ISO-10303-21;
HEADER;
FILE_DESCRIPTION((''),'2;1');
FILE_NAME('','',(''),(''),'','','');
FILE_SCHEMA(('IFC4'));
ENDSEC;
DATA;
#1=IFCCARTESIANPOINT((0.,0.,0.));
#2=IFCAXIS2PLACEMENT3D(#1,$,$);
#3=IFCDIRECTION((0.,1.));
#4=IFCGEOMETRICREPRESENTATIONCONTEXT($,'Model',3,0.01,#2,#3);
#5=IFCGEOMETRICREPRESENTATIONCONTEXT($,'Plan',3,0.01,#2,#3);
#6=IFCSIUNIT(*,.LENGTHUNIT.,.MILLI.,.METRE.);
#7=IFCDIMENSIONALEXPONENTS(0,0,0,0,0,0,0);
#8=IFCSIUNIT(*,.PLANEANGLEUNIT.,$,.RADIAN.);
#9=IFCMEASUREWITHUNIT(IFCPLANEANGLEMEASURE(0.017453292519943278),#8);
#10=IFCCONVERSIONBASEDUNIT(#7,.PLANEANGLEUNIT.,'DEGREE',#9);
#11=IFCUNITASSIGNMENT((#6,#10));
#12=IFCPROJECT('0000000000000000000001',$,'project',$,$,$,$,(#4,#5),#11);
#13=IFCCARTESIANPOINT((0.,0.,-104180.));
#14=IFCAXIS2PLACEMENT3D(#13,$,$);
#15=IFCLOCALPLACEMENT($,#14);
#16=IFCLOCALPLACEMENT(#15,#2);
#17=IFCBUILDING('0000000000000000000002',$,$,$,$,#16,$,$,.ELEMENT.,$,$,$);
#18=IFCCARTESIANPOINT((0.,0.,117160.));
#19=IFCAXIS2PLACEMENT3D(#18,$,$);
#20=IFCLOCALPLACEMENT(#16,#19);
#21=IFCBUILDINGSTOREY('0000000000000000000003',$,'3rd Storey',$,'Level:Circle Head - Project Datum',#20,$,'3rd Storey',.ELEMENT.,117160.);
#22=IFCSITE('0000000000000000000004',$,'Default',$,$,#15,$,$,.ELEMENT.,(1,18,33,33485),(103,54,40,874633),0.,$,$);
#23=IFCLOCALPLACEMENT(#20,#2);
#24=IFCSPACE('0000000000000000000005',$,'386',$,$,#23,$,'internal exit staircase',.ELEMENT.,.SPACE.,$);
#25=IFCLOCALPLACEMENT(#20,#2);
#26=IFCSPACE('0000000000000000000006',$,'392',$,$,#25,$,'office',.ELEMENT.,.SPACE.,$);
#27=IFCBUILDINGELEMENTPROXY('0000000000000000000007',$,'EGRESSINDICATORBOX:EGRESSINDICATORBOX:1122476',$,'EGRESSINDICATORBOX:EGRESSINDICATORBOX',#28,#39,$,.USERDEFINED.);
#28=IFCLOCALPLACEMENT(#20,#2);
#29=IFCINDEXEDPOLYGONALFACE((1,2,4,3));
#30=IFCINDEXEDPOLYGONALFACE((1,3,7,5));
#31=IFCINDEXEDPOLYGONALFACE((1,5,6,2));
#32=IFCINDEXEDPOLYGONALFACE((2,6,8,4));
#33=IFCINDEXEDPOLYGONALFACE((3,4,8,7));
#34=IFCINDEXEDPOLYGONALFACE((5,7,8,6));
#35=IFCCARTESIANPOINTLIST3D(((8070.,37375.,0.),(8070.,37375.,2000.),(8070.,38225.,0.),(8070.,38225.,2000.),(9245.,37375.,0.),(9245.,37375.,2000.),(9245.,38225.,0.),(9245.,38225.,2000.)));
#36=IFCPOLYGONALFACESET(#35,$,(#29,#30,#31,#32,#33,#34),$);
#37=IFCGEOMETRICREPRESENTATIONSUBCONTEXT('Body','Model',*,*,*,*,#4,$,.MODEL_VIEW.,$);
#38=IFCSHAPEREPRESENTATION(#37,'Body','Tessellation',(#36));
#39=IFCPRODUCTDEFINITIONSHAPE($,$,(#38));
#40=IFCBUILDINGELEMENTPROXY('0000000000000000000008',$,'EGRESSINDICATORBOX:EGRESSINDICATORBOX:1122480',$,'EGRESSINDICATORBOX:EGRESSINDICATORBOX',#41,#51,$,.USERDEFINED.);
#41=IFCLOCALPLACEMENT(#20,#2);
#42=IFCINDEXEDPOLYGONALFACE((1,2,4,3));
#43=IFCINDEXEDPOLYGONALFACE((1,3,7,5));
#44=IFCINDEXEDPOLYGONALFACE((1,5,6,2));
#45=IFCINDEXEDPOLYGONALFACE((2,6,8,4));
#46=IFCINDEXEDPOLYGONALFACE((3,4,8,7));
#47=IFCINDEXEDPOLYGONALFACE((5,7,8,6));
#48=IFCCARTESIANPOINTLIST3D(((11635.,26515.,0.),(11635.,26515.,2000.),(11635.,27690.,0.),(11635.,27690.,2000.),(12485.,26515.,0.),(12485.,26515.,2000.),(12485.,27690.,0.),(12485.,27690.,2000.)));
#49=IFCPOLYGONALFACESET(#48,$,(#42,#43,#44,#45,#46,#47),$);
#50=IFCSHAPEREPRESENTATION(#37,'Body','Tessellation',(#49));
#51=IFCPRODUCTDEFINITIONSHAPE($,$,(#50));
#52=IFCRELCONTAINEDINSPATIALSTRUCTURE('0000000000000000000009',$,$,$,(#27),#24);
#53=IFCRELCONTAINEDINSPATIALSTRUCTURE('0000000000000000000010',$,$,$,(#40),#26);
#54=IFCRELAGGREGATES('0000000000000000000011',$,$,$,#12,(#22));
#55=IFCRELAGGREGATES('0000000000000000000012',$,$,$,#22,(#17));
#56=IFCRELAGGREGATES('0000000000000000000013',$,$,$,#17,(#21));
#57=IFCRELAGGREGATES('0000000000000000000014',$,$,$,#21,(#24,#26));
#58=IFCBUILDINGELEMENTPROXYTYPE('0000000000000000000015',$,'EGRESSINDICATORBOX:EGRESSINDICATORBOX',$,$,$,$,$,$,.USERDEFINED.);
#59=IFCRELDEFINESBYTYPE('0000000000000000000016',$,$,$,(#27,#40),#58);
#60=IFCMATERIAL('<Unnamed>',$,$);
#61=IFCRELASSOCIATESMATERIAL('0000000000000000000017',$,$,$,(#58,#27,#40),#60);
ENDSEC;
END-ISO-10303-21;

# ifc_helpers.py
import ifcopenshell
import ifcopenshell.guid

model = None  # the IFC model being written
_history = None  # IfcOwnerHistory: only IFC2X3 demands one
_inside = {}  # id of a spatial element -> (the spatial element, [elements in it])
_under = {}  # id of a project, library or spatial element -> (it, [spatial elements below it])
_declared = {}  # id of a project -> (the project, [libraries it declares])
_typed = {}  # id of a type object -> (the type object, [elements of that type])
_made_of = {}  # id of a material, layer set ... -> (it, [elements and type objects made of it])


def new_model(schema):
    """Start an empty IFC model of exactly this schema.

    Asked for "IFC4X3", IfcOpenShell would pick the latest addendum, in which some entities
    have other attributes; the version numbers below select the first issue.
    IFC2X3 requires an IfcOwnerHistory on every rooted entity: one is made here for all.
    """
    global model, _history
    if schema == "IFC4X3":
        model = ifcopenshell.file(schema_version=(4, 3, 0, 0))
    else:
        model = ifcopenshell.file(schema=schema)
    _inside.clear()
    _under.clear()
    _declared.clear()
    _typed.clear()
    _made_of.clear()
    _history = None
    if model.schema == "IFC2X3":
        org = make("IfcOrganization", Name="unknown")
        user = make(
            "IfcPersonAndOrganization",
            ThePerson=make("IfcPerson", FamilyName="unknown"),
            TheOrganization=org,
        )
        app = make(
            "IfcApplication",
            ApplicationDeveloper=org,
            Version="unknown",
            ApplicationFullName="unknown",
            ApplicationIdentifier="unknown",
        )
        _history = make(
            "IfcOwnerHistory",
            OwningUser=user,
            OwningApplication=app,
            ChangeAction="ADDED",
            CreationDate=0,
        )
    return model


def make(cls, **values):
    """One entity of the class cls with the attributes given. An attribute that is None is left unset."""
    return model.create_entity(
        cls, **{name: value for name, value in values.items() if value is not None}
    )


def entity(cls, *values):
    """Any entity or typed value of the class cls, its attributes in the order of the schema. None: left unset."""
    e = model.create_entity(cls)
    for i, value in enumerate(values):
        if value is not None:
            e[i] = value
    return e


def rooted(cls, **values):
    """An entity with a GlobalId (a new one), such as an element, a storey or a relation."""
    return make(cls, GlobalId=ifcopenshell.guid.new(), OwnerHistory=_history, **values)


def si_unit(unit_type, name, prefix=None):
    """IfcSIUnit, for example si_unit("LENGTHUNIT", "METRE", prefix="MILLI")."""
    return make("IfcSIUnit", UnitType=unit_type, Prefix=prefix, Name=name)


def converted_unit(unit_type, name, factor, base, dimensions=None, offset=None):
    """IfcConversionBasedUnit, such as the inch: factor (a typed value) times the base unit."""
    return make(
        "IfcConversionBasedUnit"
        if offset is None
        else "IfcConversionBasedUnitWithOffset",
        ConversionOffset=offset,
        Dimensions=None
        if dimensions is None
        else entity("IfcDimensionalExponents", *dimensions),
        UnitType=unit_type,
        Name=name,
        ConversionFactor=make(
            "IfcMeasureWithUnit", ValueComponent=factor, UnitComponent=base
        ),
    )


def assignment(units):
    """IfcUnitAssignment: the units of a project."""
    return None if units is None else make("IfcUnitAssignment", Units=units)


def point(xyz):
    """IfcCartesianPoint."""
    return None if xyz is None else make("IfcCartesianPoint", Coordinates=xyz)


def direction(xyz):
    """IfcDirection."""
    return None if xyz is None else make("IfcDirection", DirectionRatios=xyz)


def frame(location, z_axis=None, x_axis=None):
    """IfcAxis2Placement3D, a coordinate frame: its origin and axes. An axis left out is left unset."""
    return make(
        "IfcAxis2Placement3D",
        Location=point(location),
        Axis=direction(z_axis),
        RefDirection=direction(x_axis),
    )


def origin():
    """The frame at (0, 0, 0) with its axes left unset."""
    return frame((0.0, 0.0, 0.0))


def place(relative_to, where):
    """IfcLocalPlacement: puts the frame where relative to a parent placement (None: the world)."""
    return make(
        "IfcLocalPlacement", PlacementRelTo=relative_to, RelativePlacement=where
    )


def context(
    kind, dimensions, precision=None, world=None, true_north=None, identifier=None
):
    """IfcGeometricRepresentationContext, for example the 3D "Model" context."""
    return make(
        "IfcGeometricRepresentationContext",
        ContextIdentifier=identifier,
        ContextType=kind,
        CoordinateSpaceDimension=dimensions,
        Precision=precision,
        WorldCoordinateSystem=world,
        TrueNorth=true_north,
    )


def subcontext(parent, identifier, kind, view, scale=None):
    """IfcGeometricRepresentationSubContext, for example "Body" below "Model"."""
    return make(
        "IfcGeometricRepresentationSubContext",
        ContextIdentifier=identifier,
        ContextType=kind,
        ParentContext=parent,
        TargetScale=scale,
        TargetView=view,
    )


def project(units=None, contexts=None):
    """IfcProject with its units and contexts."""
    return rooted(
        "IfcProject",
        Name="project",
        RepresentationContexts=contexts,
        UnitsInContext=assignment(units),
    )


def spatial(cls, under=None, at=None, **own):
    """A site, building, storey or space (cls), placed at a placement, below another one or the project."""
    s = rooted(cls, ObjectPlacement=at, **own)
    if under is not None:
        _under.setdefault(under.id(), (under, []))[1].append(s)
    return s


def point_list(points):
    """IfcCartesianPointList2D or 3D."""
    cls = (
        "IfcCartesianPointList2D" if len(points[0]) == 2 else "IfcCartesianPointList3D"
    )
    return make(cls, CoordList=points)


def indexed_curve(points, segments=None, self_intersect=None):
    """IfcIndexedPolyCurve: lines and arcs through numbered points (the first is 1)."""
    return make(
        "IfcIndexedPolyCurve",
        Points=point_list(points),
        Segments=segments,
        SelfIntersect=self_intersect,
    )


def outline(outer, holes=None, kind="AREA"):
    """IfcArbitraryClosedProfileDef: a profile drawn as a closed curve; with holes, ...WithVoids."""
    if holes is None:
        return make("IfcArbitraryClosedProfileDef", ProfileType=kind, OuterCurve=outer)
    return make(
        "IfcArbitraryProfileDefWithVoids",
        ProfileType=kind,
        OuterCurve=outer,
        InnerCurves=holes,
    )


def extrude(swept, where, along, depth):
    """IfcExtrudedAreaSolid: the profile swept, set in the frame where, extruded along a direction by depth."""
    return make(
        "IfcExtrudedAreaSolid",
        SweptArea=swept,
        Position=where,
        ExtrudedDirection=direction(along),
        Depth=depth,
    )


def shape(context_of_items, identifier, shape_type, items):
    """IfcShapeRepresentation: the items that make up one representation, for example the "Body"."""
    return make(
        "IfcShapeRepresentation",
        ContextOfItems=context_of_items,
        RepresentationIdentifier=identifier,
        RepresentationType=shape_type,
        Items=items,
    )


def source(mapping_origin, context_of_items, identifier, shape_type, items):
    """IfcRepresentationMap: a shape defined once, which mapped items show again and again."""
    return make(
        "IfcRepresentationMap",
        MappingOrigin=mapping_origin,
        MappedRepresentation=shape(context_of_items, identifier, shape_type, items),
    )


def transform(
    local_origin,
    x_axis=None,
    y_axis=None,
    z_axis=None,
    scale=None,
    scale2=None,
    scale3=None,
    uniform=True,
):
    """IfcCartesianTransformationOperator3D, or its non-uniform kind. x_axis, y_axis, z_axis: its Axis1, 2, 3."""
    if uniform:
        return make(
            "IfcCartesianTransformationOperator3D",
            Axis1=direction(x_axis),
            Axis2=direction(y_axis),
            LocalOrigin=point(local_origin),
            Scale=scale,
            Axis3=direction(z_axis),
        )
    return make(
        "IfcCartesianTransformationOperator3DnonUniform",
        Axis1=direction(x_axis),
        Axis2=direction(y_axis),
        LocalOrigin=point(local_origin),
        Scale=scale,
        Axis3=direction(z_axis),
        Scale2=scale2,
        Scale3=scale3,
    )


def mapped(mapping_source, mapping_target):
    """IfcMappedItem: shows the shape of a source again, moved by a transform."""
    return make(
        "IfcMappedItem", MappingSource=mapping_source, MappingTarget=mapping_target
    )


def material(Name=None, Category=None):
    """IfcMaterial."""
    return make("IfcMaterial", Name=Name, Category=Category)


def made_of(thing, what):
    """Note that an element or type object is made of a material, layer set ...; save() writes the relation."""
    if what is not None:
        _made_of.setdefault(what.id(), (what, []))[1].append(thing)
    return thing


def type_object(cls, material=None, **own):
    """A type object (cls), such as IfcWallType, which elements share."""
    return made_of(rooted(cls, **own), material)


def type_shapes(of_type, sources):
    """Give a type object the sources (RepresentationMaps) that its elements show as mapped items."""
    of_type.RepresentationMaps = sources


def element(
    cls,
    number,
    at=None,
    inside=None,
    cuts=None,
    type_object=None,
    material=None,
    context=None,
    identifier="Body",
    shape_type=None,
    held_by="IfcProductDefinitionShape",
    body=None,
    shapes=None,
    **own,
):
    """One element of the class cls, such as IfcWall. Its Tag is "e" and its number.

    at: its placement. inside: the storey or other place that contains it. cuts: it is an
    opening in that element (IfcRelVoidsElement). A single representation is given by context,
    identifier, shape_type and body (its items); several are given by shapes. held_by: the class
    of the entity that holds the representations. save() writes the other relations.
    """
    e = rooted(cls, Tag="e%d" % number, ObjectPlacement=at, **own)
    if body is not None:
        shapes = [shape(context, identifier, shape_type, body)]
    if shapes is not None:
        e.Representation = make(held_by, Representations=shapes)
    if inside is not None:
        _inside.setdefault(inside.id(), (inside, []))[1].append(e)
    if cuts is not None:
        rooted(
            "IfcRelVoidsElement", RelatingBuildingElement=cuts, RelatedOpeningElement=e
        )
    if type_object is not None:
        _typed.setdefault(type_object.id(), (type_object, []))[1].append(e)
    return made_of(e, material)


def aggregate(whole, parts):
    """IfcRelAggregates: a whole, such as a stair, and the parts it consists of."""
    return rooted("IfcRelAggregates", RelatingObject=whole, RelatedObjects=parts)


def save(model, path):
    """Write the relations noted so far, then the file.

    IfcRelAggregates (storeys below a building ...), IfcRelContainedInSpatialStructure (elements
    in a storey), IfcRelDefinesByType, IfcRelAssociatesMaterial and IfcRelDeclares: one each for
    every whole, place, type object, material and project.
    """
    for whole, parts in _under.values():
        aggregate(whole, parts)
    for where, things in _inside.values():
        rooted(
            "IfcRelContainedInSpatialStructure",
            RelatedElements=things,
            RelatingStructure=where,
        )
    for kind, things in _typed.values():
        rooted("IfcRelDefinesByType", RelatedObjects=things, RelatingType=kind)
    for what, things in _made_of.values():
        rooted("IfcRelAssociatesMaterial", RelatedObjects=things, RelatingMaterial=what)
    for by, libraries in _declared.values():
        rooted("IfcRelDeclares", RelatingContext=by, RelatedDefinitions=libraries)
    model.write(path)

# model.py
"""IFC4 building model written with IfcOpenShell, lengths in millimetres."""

from ifc_helpers import new_model, entity, si_unit, converted_unit, direction, frame, origin, place, context, subcontext, project, spatial, indexed_curve, outline, extrude, source, transform, mapped, material, type_object, type_shapes, element, save


model = new_model("IFC4")

# Units and contexts
model_context = context("Model", 3, precision=0.01, world=origin(), true_north=direction((0.0, 1.0)))
plan_context = context("Plan", 3, precision=0.01, world=origin(), true_north=direction((0.0, 1.0)))
body_context = subcontext(model_context, "Body", "Model", "MODEL_VIEW")
ifc_project = project(units=[si_unit("LENGTHUNIT", "METRE", prefix="MILLI"), converted_unit("PLANEANGLEUNIT", "DEGREE", entity("IfcPlaneAngleMeasure", 0.017453292519943278), si_unit("PLANEANGLEUNIT", "RADIAN"), dimensions=[0, 0, 0, 0, 0, 0, 0])], contexts=[model_context, plan_context])

# Site, building, storey
site_placement = place(None, frame((0.0, 0.0, -104180.0)))
site = spatial("IfcSite", under=ifc_project, at=site_placement, Name="Default", CompositionType="ELEMENT", RefLatitude=(1, 18, 33, 33485), RefLongitude=(103, 54, 40, 874633), RefElevation=0.0)
building_placement = place(site_placement, origin())
building = spatial("IfcBuilding", under=site, at=building_placement, CompositionType="ELEMENT")
storey_placement = place(building_placement, frame((0.0, 0.0, 117160.0)))
storey = spatial("IfcBuildingStorey", under=building, at=storey_placement, Name="3rd Storey", ObjectType="Level:Circle Head - Project Datum", LongName="3rd Storey", CompositionType="ELEMENT", Elevation=117160.0)

# Shared definitions
ifc_material_1 = material(Name="<Unnamed>")

# Shared definitions
building_element_proxy_type_1 = type_object("IfcBuildingElementProxyType", Name="EGRESSINDICATORBOX:EGRESSINDICATORBOX", PredefinedType="USERDEFINED", material=ifc_material_1)
shared_shape_1 = source(origin(), body_context, "Body", "SweptSolid", [
    extrude(outline(indexed_curve([(-425.0, -587.5), (425.0, -587.5), (425.0, 587.5), (-425.0, 587.5), (-425.0, -587.5)], self_intersect=False)), frame((0.0, 0.0, 0.0), z_axis=(0.0, 0.0, 1.0), x_axis=(-1.0, 0.0, 0.0)), (0.0, 0.0, 1.0), 2000.0),
])
type_shapes(building_element_proxy_type_1, [shared_shape_1])

# Shared definitions
space_1_placement = place(storey_placement, origin())
space_1 = spatial("IfcSpace", under=storey, at=space_1_placement, Name="386", LongName="internal exit staircase", CompositionType="ELEMENT", PredefinedType="SPACE")

# Building element proxy
proxy_1_placement = place(space_1_placement, frame((8657.5, 37800.0, 0.0), z_axis=(0.0, 0.0, 1.0), x_axis=(0.0, 1.0, 0.0)))
element("IfcBuildingElementProxy", 1, at=proxy_1_placement, inside=space_1, type_object=building_element_proxy_type_1, material=ifc_material_1, Name="EGRESSINDICATORBOX:EGRESSINDICATORBOX:1122476", ObjectType="EGRESSINDICATORBOX:EGRESSINDICATORBOX", PredefinedType="USERDEFINED", context=body_context, shape_type="MappedRepresentation", body=[
    mapped(shared_shape_1, transform((0.0, 0.0, 0.0), scale=1.0)),
])

# Shared definitions
space_2_placement = place(storey_placement, origin())
space_2 = spatial("IfcSpace", under=storey, at=space_2_placement, Name="392", LongName="office", CompositionType="ELEMENT", PredefinedType="SPACE")

# Building element proxy
proxy_2_placement = place(space_2_placement, frame((12060.0, 27102.5, 0.0)))
element("IfcBuildingElementProxy", 2, at=proxy_2_placement, inside=space_2, type_object=building_element_proxy_type_1, material=ifc_material_1, Name="EGRESSINDICATORBOX:EGRESSINDICATORBOX:1122480", ObjectType="EGRESSINDICATORBOX:EGRESSINDICATORBOX", PredefinedType="USERDEFINED", context=body_context, shape_type="MappedRepresentation", body=[
    mapped(shared_shape_1, transform((0.0, 0.0, 0.0), scale=1.0)),
])

save(model, "model.ifc")
